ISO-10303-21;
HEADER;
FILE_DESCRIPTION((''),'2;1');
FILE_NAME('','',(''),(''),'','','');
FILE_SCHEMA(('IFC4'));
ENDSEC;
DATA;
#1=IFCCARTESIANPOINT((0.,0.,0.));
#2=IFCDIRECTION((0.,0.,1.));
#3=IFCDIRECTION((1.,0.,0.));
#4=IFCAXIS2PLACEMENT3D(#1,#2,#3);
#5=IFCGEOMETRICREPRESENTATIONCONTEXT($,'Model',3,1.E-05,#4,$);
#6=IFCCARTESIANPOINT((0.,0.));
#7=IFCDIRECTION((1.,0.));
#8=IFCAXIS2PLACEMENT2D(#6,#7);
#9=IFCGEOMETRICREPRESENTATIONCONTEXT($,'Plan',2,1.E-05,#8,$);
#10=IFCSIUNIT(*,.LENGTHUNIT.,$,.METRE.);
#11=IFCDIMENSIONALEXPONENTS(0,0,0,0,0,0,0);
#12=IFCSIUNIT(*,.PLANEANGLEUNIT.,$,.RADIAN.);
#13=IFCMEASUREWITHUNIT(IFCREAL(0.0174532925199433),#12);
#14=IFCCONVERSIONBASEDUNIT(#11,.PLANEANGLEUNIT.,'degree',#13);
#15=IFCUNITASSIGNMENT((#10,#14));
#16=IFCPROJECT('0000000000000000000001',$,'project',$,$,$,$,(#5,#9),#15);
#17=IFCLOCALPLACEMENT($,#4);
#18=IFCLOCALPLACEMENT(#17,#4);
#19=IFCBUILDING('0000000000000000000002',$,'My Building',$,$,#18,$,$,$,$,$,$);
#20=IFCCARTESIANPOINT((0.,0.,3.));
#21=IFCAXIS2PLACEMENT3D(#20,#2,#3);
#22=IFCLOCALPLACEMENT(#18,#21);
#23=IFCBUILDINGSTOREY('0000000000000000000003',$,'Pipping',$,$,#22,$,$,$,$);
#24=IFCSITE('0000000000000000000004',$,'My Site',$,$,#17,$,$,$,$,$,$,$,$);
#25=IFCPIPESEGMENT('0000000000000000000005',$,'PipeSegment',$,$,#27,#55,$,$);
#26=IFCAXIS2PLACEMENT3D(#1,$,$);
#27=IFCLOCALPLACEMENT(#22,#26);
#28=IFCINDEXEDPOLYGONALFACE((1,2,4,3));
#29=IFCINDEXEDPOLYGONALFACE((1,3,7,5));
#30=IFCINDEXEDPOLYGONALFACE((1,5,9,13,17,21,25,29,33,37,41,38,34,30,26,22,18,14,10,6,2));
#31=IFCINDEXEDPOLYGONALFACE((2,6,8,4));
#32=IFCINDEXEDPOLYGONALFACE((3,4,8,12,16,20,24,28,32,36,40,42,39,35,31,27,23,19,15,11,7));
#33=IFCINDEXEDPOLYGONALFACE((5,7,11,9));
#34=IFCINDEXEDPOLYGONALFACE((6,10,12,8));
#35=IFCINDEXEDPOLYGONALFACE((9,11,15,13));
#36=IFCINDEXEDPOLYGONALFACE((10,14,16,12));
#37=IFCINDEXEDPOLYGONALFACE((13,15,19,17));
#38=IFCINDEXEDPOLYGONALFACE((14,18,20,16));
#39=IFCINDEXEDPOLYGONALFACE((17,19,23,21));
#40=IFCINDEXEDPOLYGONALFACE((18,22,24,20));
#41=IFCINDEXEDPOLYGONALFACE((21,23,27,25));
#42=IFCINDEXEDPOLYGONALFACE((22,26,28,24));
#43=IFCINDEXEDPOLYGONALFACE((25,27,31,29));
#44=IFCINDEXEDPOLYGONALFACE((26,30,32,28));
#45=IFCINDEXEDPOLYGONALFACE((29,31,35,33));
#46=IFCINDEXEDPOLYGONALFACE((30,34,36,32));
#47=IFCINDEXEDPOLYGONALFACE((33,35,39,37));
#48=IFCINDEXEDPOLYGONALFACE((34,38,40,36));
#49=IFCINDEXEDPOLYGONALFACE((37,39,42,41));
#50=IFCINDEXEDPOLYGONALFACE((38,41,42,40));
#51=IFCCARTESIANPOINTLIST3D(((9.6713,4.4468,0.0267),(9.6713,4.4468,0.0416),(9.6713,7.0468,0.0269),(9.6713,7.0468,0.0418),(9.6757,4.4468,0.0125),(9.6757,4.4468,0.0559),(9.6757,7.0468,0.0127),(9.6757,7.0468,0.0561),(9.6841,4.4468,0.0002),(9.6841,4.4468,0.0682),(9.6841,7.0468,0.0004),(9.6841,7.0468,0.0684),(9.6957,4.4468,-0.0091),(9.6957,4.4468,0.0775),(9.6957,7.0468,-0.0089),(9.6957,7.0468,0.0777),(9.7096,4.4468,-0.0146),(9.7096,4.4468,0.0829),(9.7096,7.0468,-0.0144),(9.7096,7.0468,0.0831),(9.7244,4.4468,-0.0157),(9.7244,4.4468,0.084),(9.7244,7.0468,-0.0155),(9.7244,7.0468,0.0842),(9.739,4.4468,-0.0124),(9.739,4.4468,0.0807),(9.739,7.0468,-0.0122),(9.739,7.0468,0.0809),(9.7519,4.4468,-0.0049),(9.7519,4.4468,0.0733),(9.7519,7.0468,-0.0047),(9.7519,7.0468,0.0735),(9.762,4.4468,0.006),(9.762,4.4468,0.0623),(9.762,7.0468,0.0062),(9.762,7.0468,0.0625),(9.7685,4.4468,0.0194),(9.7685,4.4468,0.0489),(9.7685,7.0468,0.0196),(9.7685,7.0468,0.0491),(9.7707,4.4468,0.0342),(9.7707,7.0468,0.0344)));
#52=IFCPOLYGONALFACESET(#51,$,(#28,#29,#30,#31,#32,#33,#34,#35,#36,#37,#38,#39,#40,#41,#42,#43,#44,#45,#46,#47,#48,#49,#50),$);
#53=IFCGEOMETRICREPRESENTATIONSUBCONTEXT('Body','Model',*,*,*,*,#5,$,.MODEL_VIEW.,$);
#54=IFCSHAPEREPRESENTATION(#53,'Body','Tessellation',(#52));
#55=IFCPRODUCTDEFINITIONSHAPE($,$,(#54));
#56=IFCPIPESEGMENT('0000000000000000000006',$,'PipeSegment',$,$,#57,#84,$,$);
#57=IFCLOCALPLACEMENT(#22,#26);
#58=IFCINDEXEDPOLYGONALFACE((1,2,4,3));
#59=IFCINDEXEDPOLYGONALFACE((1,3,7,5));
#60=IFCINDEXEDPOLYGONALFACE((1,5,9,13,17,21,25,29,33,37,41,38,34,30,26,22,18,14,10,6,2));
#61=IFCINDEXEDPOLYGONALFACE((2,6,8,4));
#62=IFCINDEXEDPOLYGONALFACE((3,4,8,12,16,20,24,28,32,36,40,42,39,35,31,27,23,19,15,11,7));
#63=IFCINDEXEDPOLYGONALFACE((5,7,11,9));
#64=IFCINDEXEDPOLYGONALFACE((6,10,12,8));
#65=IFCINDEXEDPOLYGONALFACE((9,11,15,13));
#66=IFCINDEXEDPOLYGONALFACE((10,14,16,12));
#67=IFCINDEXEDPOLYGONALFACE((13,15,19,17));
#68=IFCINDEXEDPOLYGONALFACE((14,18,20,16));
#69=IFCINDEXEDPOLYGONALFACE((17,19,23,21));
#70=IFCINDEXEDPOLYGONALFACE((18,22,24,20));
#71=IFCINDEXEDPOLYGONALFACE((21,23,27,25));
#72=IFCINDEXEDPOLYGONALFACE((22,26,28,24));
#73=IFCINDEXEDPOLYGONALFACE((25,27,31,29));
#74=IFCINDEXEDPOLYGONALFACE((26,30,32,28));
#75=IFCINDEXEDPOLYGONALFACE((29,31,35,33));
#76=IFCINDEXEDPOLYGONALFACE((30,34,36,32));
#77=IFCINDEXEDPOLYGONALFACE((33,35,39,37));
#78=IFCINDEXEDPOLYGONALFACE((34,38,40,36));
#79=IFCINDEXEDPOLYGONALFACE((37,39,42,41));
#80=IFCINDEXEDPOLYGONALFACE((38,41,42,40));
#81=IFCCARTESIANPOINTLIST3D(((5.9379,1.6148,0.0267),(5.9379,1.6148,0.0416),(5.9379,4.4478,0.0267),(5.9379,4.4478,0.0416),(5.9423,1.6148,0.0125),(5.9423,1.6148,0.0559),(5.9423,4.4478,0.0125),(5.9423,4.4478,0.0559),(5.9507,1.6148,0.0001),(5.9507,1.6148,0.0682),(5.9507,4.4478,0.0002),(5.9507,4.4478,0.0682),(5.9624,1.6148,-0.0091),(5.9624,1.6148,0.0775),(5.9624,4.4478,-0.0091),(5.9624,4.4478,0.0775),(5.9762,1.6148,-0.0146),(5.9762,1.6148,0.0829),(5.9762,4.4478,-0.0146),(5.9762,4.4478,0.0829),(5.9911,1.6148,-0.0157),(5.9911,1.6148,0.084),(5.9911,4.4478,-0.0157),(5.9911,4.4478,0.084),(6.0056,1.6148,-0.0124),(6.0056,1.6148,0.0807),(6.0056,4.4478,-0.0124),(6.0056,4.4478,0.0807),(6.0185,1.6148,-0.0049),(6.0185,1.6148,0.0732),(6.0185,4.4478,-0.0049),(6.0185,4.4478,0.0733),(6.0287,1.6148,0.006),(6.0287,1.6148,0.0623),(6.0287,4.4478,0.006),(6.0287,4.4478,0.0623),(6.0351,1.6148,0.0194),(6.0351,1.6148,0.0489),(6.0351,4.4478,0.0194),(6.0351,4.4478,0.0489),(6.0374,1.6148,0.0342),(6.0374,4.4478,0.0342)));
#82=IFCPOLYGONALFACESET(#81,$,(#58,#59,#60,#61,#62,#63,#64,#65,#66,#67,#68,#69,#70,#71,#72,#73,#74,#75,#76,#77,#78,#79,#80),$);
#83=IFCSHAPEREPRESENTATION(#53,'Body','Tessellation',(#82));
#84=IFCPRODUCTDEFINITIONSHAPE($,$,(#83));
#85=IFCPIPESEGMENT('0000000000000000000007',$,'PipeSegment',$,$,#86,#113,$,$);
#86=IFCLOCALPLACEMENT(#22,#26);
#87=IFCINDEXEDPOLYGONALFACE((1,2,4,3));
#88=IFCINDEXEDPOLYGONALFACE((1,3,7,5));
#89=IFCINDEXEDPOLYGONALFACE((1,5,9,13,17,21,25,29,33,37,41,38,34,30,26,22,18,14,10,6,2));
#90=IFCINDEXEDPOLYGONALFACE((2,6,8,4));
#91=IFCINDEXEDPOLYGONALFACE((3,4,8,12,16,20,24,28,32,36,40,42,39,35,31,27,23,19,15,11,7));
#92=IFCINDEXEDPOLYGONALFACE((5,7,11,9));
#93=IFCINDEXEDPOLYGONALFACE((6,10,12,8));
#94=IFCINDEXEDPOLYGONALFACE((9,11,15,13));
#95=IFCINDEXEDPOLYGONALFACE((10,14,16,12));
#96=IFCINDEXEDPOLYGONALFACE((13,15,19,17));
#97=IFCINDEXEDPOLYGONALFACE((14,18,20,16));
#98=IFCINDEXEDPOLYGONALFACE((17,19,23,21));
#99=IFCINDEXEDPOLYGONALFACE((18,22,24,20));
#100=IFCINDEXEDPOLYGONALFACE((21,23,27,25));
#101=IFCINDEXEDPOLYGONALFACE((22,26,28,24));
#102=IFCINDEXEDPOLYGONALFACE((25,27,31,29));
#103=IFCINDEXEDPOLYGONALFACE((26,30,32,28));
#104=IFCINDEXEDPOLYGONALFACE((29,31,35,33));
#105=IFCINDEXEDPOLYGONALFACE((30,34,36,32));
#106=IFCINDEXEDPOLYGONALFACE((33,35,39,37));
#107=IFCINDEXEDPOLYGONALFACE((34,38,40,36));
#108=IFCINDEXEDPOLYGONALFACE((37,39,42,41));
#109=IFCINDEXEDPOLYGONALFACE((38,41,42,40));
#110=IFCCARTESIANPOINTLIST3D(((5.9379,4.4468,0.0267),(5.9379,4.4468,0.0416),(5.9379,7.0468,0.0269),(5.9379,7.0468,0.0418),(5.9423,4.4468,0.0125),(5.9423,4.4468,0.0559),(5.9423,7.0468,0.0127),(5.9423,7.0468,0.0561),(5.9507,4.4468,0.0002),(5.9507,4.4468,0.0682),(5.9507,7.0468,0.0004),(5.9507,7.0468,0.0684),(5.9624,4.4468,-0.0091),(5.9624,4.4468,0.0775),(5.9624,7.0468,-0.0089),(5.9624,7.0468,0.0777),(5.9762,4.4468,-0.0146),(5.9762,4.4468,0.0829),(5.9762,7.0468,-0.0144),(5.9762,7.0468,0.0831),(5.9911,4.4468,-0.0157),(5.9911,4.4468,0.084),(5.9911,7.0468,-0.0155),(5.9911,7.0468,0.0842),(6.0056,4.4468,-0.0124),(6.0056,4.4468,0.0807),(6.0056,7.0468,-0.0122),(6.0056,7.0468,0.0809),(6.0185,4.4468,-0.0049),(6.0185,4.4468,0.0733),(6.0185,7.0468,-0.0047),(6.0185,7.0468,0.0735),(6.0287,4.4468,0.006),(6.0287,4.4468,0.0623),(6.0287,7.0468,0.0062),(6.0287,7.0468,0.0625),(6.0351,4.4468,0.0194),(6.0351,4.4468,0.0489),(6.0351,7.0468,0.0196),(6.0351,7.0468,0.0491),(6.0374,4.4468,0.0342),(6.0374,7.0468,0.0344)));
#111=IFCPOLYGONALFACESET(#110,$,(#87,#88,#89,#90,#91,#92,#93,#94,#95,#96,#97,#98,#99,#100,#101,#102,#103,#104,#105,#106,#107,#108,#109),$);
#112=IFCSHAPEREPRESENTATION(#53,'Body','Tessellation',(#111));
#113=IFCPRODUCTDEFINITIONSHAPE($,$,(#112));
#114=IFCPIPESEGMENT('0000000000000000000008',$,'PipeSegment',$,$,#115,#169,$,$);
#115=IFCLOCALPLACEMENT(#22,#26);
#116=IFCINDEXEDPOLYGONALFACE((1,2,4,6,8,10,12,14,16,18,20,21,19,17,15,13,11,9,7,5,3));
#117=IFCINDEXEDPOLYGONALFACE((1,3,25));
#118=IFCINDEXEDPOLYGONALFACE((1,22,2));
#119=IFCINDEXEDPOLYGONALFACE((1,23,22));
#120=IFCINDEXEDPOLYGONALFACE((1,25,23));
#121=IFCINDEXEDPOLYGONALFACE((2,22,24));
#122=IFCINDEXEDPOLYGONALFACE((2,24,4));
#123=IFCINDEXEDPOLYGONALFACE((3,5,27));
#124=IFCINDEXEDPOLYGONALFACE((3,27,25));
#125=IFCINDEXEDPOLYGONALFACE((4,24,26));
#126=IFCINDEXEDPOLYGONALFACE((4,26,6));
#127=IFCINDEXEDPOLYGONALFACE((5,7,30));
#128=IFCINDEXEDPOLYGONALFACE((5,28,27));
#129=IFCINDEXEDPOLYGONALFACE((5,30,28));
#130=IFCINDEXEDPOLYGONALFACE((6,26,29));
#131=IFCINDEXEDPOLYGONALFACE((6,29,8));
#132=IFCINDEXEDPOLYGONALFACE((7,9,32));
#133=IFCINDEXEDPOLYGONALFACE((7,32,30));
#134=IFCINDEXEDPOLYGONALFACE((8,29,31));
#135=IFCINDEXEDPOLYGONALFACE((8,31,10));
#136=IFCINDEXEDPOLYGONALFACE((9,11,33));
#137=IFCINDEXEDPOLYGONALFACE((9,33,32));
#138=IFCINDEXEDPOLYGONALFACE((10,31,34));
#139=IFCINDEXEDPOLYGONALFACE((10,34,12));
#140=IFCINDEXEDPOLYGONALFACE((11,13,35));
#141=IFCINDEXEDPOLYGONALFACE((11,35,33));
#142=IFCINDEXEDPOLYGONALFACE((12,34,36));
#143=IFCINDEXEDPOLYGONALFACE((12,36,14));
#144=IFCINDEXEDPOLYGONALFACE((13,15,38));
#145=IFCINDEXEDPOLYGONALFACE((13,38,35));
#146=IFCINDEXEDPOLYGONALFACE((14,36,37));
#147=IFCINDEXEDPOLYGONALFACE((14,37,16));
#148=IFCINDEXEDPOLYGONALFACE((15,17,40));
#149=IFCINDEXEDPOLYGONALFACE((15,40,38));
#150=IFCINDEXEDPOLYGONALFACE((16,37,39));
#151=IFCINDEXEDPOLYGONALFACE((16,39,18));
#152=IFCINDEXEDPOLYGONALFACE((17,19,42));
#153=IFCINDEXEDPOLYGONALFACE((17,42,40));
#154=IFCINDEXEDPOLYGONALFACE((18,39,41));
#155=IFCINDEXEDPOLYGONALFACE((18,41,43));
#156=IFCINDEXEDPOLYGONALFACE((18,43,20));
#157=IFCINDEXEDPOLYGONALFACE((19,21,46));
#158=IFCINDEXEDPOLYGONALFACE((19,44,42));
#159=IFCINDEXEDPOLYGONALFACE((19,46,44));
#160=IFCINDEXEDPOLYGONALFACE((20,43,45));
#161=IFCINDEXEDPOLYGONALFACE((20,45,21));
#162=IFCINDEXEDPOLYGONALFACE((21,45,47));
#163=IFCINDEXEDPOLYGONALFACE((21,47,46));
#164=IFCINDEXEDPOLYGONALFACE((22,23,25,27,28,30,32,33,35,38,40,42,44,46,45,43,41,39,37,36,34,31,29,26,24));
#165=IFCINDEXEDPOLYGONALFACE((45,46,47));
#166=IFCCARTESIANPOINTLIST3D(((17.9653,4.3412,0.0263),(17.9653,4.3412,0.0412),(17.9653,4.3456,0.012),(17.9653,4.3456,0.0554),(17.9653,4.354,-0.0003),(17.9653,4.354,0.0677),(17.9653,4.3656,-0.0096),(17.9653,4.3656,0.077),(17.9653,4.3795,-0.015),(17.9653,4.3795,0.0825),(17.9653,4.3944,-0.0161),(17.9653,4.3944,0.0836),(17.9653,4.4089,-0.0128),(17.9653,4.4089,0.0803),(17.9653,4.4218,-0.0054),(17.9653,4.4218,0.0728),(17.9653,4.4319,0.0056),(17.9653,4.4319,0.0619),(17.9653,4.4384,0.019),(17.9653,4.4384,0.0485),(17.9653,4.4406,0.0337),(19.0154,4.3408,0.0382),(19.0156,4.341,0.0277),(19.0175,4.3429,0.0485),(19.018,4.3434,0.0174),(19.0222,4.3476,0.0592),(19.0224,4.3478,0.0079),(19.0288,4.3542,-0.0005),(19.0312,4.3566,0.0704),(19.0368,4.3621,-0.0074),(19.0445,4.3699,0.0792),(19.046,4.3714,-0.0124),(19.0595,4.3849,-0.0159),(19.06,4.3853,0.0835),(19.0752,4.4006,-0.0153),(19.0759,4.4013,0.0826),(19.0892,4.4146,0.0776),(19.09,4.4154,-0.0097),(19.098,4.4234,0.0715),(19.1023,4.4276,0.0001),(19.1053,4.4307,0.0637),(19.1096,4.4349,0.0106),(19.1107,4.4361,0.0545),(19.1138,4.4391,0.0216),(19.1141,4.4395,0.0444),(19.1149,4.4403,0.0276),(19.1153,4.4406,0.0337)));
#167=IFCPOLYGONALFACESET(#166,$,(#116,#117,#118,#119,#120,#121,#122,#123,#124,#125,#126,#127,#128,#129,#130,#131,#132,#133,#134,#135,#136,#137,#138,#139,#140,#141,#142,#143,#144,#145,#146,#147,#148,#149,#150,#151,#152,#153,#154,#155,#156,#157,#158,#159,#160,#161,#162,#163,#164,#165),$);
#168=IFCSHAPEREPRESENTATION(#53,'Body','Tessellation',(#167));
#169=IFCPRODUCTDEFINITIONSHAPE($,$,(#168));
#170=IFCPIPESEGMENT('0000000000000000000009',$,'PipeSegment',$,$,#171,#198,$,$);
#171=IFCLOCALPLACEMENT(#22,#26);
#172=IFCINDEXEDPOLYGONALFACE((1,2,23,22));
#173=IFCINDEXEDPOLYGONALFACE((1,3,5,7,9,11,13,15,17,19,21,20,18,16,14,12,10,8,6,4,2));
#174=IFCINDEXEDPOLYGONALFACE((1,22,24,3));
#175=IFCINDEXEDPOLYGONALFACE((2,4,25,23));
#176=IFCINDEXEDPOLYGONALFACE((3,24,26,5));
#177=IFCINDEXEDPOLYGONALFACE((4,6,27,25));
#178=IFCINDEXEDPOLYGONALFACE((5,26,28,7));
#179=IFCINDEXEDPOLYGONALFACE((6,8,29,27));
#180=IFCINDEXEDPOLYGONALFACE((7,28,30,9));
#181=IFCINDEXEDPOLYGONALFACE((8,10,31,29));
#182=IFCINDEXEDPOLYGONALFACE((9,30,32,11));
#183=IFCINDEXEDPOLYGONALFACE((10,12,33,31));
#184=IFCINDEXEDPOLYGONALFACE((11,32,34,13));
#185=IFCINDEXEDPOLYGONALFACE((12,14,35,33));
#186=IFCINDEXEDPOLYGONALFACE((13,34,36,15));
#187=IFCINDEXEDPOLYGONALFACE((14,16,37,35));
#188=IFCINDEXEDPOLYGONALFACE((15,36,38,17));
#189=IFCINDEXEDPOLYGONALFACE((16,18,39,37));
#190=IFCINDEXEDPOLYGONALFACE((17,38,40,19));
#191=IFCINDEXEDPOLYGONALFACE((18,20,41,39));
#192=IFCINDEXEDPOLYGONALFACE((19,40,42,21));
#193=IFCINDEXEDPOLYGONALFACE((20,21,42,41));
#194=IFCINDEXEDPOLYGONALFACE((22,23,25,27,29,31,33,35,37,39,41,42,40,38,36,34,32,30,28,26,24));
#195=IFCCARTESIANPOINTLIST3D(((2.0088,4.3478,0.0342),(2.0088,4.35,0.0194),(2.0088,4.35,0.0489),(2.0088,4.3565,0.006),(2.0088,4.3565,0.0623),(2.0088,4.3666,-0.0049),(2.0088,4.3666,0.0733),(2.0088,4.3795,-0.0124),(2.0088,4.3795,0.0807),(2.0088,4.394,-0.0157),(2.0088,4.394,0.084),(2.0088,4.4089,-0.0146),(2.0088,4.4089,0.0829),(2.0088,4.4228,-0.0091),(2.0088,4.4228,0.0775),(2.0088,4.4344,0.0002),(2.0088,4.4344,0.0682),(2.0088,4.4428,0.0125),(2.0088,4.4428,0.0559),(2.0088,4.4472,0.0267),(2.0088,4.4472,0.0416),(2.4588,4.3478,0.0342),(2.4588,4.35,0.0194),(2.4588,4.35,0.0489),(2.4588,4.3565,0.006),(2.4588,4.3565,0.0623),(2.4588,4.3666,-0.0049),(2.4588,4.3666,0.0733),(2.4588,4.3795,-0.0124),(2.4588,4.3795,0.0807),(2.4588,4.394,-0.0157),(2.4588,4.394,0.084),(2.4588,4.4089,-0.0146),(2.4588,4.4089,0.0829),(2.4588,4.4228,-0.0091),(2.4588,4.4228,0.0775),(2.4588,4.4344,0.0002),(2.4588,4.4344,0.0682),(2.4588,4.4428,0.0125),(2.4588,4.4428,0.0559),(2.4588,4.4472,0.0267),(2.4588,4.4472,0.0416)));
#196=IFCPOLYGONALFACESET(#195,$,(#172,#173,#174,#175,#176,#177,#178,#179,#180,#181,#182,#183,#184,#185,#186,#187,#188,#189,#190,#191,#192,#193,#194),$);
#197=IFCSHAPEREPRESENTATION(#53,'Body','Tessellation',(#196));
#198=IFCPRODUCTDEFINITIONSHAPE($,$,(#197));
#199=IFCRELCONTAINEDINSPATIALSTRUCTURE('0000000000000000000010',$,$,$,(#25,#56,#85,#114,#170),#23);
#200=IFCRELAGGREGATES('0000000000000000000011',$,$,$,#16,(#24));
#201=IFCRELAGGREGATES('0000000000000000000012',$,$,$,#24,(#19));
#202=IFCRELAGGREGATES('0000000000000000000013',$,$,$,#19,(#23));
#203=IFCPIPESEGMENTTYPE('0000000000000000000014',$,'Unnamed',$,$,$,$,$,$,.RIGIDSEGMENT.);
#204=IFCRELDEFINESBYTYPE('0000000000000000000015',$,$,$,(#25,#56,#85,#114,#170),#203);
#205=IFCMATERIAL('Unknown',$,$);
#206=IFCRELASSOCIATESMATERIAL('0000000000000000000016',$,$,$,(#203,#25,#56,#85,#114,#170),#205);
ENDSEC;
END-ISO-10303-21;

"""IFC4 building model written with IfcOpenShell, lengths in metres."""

from ifc_helpers import new_model, entity, si_unit, converted_unit, frame, origin_with_axes, origin_2d_with_axis, place, context, subcontext, project, spatial, circle, extrude, clip, halfspace, material, material_profile, profile_set, profile_usage, type_object, element, save


model = new_model("IFC4")

# Units and contexts
model_context = context("Model", 3, precision=1e-05, world=origin_with_axes())
plan_context = context("Plan", 2, precision=1e-05, world=origin_2d_with_axis())
body_context = subcontext(model_context, "Body", "Model", "MODEL_VIEW")
ifc_project = project(units=[si_unit("LENGTHUNIT", "METRE"), converted_unit("PLANEANGLEUNIT", "degree", entity("IfcReal", 0.0174532925199433), si_unit("PLANEANGLEUNIT", "RADIAN"), dimensions=[0, 0, 0, 0, 0, 0, 0])], contexts=[model_context, plan_context])

# Site, building, storey
site_placement = place(None, origin_with_axes())
site = spatial("IfcSite", under=ifc_project, at=site_placement, Name="My Site")
building_placement = place(site_placement, origin_with_axes())
building = spatial("IfcBuilding", under=site, at=building_placement, Name="My Building")
storey_placement = place(building_placement, frame((0.0, 0.0, 3.0), z_axis=(0.0, 0.0, 1.0), x_axis=(1.0, 0.0, 0.0)))
storey = spatial("IfcBuildingStorey", under=building, at=storey_placement, Name="Pipping")

# Pipe segments
ifc_material = material(Name="Unknown")
ifc_material_profile_1 = material_profile(ifc_material, circle(Radius=0.05))
ifc_profile_set_1 = profile_set([ifc_material_profile_1])
pipe_segment_type = type_object("IfcPipeSegmentType", Name="Unnamed", PredefinedType="RIGIDSEGMENT", material=ifc_profile_set_1)
ifc_profile_usage_1 = profile_usage(ifc_profile_set_1, cardinal=5)
pipe_segment_1_placement = place(storey_placement, frame((9.7207, 4.4468, 0.0342), z_axis=(0.0, 1.0, 0.000073), x_axis=(1.0, 0.0, 0.0)))
element("IfcPipeSegment", 1, at=pipe_segment_1_placement, inside=storey, type_object=pipe_segment_type, material=ifc_profile_usage_1, Name="PipeSegment", context=body_context, shape_type="SweptSolid", body=[
    extrude(circle(Radius=0.05), origin_with_axes(), (0.0, 0.0, 1.0), 2.6),
])
ifc_profile_usage_2 = profile_usage(ifc_profile_set_1, cardinal=5)
pipe_segment_2_placement = place(storey_placement, frame((5.9874, 4.4478, 0.0342), z_axis=(0.0, -1.0, -0.000004), x_axis=(1.0, 0.0, 0.0)))
element("IfcPipeSegment", 2, at=pipe_segment_2_placement, inside=storey, type_object=pipe_segment_type, material=ifc_profile_usage_2, Name="PipeSegment", context=body_context, shape_type="SweptSolid", body=[
    extrude(circle(Radius=0.05), origin_with_axes(), (0.0, 0.0, 1.0), 2.8329),
])
ifc_profile_usage_3 = profile_usage(ifc_profile_set_1, cardinal=5)
pipe_segment_3_placement = place(storey_placement, frame((5.9874, 4.4468, 0.0342), z_axis=(0.0, 1.0, 0.000073), x_axis=(1.0, 0.0, 0.0)))
element("IfcPipeSegment", 3, at=pipe_segment_3_placement, inside=storey, type_object=pipe_segment_type, material=ifc_profile_usage_3, Name="PipeSegment", context=body_context, shape_type="SweptSolid", body=[
    extrude(circle(Radius=0.05), origin_with_axes(), (0.0, 0.0, 1.0), 2.6),
])
ifc_profile_usage_4 = profile_usage(ifc_profile_set_1, cardinal=5)
pipe_segment_4_placement = place(storey_placement, frame((17.9653, 4.3906, 0.0337), z_axis=(1.0, 0.0, 0.0), x_axis=(0.0, 1.0, 0.0)))
element("IfcPipeSegment", 4, at=pipe_segment_4_placement, inside=storey, type_object=pipe_segment_type, material=ifc_profile_usage_4, Name="PipeSegment", context=body_context, shape_type="Clipping", body=[
    clip(extrude(circle(Radius=0.05), origin_with_axes(), (0.0, 0.0, 1.0), 1.15), halfspace(frame((0.05, -3.0671, 1.15), z_axis=(-0.7071, 0.0, 0.707114), x_axis=(0.0, 1.0, 0.0)), False)),
])
ifc_profile_usage_5 = profile_usage(ifc_profile_set_1, cardinal=5)
pipe_segment_5_placement = place(storey_placement, frame((2.4588, 4.3978, 0.0342), z_axis=(-1.0, 0.0, 0.0), x_axis=(0.0, -1.0, 0.0)))
element("IfcPipeSegment", 5, at=pipe_segment_5_placement, inside=storey, type_object=pipe_segment_type, material=ifc_profile_usage_5, Name="PipeSegment", context=body_context, shape_type="SweptSolid", body=[
    extrude(circle(Radius=0.05), origin_with_axes(), (0.0, 0.0, 1.0), 0.45),
])

save(model, "model.ifc")
